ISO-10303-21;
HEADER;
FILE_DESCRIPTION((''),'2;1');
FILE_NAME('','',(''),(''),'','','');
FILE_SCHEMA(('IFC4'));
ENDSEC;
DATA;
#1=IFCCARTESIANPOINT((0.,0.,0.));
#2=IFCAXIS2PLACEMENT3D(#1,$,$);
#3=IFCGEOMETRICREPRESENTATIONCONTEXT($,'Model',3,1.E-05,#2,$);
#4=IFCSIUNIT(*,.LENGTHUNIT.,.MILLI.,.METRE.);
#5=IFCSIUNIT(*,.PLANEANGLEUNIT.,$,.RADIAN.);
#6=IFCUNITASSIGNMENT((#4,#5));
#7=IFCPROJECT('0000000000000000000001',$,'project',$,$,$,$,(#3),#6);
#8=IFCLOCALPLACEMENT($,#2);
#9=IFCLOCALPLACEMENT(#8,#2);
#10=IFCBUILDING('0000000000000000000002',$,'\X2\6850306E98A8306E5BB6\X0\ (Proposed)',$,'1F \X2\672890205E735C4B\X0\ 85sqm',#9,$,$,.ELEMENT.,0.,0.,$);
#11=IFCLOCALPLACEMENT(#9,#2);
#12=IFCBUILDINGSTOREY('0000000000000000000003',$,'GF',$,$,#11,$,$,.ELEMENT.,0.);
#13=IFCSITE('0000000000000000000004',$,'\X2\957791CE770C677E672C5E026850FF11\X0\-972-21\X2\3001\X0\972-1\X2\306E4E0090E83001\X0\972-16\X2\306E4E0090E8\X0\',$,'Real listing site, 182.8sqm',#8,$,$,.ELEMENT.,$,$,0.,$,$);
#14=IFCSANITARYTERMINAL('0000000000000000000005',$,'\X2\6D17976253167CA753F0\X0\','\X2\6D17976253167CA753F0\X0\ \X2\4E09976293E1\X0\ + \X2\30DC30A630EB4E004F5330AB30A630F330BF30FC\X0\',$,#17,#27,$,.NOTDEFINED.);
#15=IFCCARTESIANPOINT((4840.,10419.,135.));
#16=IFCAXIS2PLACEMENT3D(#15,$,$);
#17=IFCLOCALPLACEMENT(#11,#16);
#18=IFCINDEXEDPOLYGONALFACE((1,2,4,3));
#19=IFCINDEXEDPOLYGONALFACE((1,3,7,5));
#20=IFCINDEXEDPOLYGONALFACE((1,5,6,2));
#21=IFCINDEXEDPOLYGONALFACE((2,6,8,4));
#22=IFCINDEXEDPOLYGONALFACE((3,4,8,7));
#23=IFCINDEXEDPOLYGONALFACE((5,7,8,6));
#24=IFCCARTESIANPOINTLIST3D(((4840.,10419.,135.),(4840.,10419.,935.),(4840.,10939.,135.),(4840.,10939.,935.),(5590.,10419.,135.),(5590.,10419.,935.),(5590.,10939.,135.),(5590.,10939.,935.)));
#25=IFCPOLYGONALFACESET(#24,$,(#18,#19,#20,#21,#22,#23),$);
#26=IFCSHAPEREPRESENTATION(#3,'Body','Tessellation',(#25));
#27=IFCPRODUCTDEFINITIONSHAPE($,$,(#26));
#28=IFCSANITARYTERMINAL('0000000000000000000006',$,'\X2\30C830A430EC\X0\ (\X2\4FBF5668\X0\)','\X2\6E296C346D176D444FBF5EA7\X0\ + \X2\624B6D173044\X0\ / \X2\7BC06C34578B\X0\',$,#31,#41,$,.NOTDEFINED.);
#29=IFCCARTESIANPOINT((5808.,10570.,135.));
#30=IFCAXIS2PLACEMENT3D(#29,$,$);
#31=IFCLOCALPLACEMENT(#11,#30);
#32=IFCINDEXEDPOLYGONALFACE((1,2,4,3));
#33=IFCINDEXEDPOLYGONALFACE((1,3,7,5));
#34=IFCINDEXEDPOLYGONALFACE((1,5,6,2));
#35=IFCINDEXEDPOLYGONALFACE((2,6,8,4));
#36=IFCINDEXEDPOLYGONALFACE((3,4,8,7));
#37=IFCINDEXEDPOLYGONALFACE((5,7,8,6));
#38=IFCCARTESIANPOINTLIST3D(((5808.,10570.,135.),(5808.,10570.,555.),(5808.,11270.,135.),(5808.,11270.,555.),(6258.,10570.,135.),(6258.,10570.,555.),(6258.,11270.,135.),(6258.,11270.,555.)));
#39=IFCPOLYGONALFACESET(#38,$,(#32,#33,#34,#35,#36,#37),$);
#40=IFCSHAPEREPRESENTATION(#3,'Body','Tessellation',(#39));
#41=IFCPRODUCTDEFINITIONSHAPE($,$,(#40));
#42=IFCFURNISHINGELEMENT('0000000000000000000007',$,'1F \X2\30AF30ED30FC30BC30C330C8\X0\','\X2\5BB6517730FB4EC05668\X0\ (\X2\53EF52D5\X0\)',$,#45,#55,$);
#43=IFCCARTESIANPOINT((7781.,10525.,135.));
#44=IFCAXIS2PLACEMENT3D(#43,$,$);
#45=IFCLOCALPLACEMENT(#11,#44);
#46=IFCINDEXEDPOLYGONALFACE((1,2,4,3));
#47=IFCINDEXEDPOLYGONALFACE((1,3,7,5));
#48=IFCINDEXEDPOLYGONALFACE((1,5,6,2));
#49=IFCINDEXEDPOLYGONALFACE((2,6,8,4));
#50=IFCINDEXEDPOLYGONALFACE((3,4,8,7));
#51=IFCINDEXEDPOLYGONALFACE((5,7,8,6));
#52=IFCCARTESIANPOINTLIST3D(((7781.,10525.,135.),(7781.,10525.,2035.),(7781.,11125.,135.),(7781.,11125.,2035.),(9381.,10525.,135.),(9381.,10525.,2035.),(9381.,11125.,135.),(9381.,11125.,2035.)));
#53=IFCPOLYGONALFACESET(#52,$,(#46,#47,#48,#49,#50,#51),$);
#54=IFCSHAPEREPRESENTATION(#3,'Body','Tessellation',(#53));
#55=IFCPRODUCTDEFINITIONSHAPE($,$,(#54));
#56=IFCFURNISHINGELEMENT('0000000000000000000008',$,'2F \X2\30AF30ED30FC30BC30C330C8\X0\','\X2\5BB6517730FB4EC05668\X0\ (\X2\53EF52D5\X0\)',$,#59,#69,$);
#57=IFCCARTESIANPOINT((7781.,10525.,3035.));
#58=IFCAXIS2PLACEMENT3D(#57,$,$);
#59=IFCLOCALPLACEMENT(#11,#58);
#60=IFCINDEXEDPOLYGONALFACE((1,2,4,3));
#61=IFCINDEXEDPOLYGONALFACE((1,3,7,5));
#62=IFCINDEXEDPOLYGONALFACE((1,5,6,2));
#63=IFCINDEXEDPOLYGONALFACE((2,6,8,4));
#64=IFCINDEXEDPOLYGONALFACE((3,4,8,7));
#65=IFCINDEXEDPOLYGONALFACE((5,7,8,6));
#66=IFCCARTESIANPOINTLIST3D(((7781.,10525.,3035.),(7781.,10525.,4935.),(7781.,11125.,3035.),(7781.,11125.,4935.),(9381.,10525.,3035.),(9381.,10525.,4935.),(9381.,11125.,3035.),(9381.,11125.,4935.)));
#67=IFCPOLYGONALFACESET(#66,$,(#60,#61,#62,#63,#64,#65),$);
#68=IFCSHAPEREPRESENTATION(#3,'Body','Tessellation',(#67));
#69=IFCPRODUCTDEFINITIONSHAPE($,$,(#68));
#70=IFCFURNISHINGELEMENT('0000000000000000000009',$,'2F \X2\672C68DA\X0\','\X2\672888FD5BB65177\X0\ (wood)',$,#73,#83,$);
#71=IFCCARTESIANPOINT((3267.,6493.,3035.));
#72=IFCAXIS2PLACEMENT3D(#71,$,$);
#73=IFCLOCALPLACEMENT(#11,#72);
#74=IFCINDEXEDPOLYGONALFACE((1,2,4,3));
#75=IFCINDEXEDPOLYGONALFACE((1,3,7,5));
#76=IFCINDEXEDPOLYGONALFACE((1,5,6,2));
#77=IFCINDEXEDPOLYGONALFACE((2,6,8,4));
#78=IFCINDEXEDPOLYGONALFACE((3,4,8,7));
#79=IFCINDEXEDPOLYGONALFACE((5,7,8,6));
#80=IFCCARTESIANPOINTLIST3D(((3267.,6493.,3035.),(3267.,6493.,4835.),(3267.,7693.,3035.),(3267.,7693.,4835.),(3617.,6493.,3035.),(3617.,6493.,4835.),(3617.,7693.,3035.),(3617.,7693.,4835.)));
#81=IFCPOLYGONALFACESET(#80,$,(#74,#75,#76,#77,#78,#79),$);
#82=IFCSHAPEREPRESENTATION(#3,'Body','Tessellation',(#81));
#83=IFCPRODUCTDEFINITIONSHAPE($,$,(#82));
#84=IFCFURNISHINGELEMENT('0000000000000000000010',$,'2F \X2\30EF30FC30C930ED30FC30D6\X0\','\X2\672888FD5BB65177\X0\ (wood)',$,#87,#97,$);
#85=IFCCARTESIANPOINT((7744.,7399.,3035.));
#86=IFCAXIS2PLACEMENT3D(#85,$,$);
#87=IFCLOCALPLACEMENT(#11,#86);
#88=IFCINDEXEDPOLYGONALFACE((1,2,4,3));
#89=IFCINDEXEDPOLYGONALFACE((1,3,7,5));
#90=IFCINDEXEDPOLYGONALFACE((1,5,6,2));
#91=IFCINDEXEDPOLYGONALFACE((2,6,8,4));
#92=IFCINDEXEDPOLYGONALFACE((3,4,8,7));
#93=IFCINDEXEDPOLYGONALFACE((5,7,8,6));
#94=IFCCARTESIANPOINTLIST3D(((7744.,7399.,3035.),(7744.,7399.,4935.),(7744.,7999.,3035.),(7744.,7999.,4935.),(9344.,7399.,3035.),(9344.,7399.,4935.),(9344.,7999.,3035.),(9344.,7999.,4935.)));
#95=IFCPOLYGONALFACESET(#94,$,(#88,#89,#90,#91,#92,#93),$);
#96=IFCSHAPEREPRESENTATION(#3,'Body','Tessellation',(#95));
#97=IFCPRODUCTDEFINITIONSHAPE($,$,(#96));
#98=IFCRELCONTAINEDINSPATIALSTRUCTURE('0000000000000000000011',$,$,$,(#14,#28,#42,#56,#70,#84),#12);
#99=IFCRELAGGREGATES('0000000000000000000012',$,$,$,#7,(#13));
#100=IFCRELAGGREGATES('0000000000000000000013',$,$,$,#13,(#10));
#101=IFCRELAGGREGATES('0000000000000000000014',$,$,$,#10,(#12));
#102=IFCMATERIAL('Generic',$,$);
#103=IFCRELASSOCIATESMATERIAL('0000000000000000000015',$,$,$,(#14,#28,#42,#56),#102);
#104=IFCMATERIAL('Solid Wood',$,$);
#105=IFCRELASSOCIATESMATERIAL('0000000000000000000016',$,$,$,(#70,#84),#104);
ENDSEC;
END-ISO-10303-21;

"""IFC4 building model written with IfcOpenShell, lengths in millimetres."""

from ifc_helpers import new_model, si_unit, frame, frame_2d, origin, place, context, project, spatial, rectangle, extrude, material, element, save


model = new_model("IFC4")

# Units and contexts
model_context = context("Model", 3, precision=1e-05, world=origin())
ifc_project = project(units=[si_unit("LENGTHUNIT", "METRE", prefix="MILLI"), si_unit("PLANEANGLEUNIT", "RADIAN")], contexts=[model_context])

# Site, building, storey
site_placement = place(None, origin())
site = spatial("IfcSite", under=ifc_project, at=site_placement, Name="長野県松本市桐１-972-21、972-1の一部、972-16の一部", ObjectType="Real listing site, 182.8sqm", CompositionType="ELEMENT", RefElevation=0.0)
building_placement = place(site_placement, origin())
building = spatial("IfcBuilding", under=site, at=building_placement, Name="桐の風の家 (Proposed)", ObjectType="1F 木造平屋 85sqm", CompositionType="ELEMENT", ElevationOfRefHeight=0.0, ElevationOfTerrain=0.0)
storey_placement = place(building_placement, origin())
storey = spatial("IfcBuildingStorey", under=building, at=storey_placement, Name="GF", CompositionType="ELEMENT", Elevation=0.0)

# Shared definitions
ifc_material_1 = material(Name="Solid Wood")

# Shared definitions
ifc_material_2 = material(Name="Generic")

# Sanitary terminals
sanitary_terminal_1_placement = place(storey_placement, frame((4840.0, 10419.0, 135.0)))
element("IfcSanitaryTerminal", 1, at=sanitary_terminal_1_placement, inside=storey, material=ifc_material_2, Name="洗面化粧台", Description="洗面化粧台 三面鏡 + ボウル一体カウンター", PredefinedType="NOTDEFINED", context=model_context, shape_type="SweptSolid", body=[
    extrude(rectangle(XDim=750.0, YDim=520.0, at=frame_2d((375.0, 260.0))), frame((4840.0, 10419.0, 135.0)), (0.0, 0.0, 1.0), 800.0),
])
sanitary_terminal_2_placement = place(storey_placement, frame((5808.0, 10570.0, 135.0)))
element("IfcSanitaryTerminal", 2, at=sanitary_terminal_2_placement, inside=storey, material=ifc_material_2, Name="トイレ (便器)", Description="温水洗浄便座 + 手洗い / 節水型", PredefinedType="NOTDEFINED", context=model_context, shape_type="SweptSolid", body=[
    extrude(rectangle(XDim=450.0, YDim=700.0, at=frame_2d((225.0, 350.0))), frame((5808.0, 10570.0, 135.0)), (0.0, 0.0, 1.0), 420.0),
])

# Furnishing elements
furnishing_1_placement = place(storey_placement, frame((7781.0, 10525.0, 135.0)))
element("IfcFurnishingElement", 3, at=furnishing_1_placement, inside=storey, material=ifc_material_2, Name="1F クローゼット", Description="家具・什器 (可動)", context=model_context, shape_type="SweptSolid", body=[
    extrude(rectangle(XDim=1600.0, YDim=600.0, at=frame_2d((800.0, 300.0))), frame((7781.0, 10525.0, 135.0)), (0.0, 0.0, 1.0), 1900.0),
])
furnishing_2_placement = place(storey_placement, frame((7781.0, 10525.0, 3035.0)))
element("IfcFurnishingElement", 4, at=furnishing_2_placement, inside=storey, material=ifc_material_2, Name="2F クローゼット", Description="家具・什器 (可動)", context=model_context, shape_type="SweptSolid", body=[
    extrude(rectangle(XDim=1600.0, YDim=600.0, at=frame_2d((800.0, 300.0))), frame((7781.0, 10525.0, 3035.0)), (0.0, 0.0, 1.0), 1900.0),
])
furnishing_3_placement = place(storey_placement, frame((3267.0, 6493.0, 3035.0)))
element("IfcFurnishingElement", 5, at=furnishing_3_placement, inside=storey, material=ifc_material_1, Name="2F 本棚", Description="木製家具 (wood)", context=model_context, shape_type="SweptSolid", body=[
    extrude(rectangle(XDim=350.0, YDim=1200.0, at=frame_2d((175.0, 600.0))), frame((3267.0, 6493.0, 3035.0)), (0.0, 0.0, 1.0), 1800.0),
])
furnishing_4_placement = place(storey_placement, frame((7744.0, 7399.0, 3035.0)))
element("IfcFurnishingElement", 6, at=furnishing_4_placement, inside=storey, material=ifc_material_1, Name="2F ワードローブ", Description="木製家具 (wood)", context=model_context, shape_type="SweptSolid", body=[
    extrude(rectangle(XDim=1600.0, YDim=600.0, at=frame_2d((800.0, 300.0))), frame((7744.0, 7399.0, 3035.0)), (0.0, 0.0, 1.0), 1900.0),
])

save(model, "model.ifc")
